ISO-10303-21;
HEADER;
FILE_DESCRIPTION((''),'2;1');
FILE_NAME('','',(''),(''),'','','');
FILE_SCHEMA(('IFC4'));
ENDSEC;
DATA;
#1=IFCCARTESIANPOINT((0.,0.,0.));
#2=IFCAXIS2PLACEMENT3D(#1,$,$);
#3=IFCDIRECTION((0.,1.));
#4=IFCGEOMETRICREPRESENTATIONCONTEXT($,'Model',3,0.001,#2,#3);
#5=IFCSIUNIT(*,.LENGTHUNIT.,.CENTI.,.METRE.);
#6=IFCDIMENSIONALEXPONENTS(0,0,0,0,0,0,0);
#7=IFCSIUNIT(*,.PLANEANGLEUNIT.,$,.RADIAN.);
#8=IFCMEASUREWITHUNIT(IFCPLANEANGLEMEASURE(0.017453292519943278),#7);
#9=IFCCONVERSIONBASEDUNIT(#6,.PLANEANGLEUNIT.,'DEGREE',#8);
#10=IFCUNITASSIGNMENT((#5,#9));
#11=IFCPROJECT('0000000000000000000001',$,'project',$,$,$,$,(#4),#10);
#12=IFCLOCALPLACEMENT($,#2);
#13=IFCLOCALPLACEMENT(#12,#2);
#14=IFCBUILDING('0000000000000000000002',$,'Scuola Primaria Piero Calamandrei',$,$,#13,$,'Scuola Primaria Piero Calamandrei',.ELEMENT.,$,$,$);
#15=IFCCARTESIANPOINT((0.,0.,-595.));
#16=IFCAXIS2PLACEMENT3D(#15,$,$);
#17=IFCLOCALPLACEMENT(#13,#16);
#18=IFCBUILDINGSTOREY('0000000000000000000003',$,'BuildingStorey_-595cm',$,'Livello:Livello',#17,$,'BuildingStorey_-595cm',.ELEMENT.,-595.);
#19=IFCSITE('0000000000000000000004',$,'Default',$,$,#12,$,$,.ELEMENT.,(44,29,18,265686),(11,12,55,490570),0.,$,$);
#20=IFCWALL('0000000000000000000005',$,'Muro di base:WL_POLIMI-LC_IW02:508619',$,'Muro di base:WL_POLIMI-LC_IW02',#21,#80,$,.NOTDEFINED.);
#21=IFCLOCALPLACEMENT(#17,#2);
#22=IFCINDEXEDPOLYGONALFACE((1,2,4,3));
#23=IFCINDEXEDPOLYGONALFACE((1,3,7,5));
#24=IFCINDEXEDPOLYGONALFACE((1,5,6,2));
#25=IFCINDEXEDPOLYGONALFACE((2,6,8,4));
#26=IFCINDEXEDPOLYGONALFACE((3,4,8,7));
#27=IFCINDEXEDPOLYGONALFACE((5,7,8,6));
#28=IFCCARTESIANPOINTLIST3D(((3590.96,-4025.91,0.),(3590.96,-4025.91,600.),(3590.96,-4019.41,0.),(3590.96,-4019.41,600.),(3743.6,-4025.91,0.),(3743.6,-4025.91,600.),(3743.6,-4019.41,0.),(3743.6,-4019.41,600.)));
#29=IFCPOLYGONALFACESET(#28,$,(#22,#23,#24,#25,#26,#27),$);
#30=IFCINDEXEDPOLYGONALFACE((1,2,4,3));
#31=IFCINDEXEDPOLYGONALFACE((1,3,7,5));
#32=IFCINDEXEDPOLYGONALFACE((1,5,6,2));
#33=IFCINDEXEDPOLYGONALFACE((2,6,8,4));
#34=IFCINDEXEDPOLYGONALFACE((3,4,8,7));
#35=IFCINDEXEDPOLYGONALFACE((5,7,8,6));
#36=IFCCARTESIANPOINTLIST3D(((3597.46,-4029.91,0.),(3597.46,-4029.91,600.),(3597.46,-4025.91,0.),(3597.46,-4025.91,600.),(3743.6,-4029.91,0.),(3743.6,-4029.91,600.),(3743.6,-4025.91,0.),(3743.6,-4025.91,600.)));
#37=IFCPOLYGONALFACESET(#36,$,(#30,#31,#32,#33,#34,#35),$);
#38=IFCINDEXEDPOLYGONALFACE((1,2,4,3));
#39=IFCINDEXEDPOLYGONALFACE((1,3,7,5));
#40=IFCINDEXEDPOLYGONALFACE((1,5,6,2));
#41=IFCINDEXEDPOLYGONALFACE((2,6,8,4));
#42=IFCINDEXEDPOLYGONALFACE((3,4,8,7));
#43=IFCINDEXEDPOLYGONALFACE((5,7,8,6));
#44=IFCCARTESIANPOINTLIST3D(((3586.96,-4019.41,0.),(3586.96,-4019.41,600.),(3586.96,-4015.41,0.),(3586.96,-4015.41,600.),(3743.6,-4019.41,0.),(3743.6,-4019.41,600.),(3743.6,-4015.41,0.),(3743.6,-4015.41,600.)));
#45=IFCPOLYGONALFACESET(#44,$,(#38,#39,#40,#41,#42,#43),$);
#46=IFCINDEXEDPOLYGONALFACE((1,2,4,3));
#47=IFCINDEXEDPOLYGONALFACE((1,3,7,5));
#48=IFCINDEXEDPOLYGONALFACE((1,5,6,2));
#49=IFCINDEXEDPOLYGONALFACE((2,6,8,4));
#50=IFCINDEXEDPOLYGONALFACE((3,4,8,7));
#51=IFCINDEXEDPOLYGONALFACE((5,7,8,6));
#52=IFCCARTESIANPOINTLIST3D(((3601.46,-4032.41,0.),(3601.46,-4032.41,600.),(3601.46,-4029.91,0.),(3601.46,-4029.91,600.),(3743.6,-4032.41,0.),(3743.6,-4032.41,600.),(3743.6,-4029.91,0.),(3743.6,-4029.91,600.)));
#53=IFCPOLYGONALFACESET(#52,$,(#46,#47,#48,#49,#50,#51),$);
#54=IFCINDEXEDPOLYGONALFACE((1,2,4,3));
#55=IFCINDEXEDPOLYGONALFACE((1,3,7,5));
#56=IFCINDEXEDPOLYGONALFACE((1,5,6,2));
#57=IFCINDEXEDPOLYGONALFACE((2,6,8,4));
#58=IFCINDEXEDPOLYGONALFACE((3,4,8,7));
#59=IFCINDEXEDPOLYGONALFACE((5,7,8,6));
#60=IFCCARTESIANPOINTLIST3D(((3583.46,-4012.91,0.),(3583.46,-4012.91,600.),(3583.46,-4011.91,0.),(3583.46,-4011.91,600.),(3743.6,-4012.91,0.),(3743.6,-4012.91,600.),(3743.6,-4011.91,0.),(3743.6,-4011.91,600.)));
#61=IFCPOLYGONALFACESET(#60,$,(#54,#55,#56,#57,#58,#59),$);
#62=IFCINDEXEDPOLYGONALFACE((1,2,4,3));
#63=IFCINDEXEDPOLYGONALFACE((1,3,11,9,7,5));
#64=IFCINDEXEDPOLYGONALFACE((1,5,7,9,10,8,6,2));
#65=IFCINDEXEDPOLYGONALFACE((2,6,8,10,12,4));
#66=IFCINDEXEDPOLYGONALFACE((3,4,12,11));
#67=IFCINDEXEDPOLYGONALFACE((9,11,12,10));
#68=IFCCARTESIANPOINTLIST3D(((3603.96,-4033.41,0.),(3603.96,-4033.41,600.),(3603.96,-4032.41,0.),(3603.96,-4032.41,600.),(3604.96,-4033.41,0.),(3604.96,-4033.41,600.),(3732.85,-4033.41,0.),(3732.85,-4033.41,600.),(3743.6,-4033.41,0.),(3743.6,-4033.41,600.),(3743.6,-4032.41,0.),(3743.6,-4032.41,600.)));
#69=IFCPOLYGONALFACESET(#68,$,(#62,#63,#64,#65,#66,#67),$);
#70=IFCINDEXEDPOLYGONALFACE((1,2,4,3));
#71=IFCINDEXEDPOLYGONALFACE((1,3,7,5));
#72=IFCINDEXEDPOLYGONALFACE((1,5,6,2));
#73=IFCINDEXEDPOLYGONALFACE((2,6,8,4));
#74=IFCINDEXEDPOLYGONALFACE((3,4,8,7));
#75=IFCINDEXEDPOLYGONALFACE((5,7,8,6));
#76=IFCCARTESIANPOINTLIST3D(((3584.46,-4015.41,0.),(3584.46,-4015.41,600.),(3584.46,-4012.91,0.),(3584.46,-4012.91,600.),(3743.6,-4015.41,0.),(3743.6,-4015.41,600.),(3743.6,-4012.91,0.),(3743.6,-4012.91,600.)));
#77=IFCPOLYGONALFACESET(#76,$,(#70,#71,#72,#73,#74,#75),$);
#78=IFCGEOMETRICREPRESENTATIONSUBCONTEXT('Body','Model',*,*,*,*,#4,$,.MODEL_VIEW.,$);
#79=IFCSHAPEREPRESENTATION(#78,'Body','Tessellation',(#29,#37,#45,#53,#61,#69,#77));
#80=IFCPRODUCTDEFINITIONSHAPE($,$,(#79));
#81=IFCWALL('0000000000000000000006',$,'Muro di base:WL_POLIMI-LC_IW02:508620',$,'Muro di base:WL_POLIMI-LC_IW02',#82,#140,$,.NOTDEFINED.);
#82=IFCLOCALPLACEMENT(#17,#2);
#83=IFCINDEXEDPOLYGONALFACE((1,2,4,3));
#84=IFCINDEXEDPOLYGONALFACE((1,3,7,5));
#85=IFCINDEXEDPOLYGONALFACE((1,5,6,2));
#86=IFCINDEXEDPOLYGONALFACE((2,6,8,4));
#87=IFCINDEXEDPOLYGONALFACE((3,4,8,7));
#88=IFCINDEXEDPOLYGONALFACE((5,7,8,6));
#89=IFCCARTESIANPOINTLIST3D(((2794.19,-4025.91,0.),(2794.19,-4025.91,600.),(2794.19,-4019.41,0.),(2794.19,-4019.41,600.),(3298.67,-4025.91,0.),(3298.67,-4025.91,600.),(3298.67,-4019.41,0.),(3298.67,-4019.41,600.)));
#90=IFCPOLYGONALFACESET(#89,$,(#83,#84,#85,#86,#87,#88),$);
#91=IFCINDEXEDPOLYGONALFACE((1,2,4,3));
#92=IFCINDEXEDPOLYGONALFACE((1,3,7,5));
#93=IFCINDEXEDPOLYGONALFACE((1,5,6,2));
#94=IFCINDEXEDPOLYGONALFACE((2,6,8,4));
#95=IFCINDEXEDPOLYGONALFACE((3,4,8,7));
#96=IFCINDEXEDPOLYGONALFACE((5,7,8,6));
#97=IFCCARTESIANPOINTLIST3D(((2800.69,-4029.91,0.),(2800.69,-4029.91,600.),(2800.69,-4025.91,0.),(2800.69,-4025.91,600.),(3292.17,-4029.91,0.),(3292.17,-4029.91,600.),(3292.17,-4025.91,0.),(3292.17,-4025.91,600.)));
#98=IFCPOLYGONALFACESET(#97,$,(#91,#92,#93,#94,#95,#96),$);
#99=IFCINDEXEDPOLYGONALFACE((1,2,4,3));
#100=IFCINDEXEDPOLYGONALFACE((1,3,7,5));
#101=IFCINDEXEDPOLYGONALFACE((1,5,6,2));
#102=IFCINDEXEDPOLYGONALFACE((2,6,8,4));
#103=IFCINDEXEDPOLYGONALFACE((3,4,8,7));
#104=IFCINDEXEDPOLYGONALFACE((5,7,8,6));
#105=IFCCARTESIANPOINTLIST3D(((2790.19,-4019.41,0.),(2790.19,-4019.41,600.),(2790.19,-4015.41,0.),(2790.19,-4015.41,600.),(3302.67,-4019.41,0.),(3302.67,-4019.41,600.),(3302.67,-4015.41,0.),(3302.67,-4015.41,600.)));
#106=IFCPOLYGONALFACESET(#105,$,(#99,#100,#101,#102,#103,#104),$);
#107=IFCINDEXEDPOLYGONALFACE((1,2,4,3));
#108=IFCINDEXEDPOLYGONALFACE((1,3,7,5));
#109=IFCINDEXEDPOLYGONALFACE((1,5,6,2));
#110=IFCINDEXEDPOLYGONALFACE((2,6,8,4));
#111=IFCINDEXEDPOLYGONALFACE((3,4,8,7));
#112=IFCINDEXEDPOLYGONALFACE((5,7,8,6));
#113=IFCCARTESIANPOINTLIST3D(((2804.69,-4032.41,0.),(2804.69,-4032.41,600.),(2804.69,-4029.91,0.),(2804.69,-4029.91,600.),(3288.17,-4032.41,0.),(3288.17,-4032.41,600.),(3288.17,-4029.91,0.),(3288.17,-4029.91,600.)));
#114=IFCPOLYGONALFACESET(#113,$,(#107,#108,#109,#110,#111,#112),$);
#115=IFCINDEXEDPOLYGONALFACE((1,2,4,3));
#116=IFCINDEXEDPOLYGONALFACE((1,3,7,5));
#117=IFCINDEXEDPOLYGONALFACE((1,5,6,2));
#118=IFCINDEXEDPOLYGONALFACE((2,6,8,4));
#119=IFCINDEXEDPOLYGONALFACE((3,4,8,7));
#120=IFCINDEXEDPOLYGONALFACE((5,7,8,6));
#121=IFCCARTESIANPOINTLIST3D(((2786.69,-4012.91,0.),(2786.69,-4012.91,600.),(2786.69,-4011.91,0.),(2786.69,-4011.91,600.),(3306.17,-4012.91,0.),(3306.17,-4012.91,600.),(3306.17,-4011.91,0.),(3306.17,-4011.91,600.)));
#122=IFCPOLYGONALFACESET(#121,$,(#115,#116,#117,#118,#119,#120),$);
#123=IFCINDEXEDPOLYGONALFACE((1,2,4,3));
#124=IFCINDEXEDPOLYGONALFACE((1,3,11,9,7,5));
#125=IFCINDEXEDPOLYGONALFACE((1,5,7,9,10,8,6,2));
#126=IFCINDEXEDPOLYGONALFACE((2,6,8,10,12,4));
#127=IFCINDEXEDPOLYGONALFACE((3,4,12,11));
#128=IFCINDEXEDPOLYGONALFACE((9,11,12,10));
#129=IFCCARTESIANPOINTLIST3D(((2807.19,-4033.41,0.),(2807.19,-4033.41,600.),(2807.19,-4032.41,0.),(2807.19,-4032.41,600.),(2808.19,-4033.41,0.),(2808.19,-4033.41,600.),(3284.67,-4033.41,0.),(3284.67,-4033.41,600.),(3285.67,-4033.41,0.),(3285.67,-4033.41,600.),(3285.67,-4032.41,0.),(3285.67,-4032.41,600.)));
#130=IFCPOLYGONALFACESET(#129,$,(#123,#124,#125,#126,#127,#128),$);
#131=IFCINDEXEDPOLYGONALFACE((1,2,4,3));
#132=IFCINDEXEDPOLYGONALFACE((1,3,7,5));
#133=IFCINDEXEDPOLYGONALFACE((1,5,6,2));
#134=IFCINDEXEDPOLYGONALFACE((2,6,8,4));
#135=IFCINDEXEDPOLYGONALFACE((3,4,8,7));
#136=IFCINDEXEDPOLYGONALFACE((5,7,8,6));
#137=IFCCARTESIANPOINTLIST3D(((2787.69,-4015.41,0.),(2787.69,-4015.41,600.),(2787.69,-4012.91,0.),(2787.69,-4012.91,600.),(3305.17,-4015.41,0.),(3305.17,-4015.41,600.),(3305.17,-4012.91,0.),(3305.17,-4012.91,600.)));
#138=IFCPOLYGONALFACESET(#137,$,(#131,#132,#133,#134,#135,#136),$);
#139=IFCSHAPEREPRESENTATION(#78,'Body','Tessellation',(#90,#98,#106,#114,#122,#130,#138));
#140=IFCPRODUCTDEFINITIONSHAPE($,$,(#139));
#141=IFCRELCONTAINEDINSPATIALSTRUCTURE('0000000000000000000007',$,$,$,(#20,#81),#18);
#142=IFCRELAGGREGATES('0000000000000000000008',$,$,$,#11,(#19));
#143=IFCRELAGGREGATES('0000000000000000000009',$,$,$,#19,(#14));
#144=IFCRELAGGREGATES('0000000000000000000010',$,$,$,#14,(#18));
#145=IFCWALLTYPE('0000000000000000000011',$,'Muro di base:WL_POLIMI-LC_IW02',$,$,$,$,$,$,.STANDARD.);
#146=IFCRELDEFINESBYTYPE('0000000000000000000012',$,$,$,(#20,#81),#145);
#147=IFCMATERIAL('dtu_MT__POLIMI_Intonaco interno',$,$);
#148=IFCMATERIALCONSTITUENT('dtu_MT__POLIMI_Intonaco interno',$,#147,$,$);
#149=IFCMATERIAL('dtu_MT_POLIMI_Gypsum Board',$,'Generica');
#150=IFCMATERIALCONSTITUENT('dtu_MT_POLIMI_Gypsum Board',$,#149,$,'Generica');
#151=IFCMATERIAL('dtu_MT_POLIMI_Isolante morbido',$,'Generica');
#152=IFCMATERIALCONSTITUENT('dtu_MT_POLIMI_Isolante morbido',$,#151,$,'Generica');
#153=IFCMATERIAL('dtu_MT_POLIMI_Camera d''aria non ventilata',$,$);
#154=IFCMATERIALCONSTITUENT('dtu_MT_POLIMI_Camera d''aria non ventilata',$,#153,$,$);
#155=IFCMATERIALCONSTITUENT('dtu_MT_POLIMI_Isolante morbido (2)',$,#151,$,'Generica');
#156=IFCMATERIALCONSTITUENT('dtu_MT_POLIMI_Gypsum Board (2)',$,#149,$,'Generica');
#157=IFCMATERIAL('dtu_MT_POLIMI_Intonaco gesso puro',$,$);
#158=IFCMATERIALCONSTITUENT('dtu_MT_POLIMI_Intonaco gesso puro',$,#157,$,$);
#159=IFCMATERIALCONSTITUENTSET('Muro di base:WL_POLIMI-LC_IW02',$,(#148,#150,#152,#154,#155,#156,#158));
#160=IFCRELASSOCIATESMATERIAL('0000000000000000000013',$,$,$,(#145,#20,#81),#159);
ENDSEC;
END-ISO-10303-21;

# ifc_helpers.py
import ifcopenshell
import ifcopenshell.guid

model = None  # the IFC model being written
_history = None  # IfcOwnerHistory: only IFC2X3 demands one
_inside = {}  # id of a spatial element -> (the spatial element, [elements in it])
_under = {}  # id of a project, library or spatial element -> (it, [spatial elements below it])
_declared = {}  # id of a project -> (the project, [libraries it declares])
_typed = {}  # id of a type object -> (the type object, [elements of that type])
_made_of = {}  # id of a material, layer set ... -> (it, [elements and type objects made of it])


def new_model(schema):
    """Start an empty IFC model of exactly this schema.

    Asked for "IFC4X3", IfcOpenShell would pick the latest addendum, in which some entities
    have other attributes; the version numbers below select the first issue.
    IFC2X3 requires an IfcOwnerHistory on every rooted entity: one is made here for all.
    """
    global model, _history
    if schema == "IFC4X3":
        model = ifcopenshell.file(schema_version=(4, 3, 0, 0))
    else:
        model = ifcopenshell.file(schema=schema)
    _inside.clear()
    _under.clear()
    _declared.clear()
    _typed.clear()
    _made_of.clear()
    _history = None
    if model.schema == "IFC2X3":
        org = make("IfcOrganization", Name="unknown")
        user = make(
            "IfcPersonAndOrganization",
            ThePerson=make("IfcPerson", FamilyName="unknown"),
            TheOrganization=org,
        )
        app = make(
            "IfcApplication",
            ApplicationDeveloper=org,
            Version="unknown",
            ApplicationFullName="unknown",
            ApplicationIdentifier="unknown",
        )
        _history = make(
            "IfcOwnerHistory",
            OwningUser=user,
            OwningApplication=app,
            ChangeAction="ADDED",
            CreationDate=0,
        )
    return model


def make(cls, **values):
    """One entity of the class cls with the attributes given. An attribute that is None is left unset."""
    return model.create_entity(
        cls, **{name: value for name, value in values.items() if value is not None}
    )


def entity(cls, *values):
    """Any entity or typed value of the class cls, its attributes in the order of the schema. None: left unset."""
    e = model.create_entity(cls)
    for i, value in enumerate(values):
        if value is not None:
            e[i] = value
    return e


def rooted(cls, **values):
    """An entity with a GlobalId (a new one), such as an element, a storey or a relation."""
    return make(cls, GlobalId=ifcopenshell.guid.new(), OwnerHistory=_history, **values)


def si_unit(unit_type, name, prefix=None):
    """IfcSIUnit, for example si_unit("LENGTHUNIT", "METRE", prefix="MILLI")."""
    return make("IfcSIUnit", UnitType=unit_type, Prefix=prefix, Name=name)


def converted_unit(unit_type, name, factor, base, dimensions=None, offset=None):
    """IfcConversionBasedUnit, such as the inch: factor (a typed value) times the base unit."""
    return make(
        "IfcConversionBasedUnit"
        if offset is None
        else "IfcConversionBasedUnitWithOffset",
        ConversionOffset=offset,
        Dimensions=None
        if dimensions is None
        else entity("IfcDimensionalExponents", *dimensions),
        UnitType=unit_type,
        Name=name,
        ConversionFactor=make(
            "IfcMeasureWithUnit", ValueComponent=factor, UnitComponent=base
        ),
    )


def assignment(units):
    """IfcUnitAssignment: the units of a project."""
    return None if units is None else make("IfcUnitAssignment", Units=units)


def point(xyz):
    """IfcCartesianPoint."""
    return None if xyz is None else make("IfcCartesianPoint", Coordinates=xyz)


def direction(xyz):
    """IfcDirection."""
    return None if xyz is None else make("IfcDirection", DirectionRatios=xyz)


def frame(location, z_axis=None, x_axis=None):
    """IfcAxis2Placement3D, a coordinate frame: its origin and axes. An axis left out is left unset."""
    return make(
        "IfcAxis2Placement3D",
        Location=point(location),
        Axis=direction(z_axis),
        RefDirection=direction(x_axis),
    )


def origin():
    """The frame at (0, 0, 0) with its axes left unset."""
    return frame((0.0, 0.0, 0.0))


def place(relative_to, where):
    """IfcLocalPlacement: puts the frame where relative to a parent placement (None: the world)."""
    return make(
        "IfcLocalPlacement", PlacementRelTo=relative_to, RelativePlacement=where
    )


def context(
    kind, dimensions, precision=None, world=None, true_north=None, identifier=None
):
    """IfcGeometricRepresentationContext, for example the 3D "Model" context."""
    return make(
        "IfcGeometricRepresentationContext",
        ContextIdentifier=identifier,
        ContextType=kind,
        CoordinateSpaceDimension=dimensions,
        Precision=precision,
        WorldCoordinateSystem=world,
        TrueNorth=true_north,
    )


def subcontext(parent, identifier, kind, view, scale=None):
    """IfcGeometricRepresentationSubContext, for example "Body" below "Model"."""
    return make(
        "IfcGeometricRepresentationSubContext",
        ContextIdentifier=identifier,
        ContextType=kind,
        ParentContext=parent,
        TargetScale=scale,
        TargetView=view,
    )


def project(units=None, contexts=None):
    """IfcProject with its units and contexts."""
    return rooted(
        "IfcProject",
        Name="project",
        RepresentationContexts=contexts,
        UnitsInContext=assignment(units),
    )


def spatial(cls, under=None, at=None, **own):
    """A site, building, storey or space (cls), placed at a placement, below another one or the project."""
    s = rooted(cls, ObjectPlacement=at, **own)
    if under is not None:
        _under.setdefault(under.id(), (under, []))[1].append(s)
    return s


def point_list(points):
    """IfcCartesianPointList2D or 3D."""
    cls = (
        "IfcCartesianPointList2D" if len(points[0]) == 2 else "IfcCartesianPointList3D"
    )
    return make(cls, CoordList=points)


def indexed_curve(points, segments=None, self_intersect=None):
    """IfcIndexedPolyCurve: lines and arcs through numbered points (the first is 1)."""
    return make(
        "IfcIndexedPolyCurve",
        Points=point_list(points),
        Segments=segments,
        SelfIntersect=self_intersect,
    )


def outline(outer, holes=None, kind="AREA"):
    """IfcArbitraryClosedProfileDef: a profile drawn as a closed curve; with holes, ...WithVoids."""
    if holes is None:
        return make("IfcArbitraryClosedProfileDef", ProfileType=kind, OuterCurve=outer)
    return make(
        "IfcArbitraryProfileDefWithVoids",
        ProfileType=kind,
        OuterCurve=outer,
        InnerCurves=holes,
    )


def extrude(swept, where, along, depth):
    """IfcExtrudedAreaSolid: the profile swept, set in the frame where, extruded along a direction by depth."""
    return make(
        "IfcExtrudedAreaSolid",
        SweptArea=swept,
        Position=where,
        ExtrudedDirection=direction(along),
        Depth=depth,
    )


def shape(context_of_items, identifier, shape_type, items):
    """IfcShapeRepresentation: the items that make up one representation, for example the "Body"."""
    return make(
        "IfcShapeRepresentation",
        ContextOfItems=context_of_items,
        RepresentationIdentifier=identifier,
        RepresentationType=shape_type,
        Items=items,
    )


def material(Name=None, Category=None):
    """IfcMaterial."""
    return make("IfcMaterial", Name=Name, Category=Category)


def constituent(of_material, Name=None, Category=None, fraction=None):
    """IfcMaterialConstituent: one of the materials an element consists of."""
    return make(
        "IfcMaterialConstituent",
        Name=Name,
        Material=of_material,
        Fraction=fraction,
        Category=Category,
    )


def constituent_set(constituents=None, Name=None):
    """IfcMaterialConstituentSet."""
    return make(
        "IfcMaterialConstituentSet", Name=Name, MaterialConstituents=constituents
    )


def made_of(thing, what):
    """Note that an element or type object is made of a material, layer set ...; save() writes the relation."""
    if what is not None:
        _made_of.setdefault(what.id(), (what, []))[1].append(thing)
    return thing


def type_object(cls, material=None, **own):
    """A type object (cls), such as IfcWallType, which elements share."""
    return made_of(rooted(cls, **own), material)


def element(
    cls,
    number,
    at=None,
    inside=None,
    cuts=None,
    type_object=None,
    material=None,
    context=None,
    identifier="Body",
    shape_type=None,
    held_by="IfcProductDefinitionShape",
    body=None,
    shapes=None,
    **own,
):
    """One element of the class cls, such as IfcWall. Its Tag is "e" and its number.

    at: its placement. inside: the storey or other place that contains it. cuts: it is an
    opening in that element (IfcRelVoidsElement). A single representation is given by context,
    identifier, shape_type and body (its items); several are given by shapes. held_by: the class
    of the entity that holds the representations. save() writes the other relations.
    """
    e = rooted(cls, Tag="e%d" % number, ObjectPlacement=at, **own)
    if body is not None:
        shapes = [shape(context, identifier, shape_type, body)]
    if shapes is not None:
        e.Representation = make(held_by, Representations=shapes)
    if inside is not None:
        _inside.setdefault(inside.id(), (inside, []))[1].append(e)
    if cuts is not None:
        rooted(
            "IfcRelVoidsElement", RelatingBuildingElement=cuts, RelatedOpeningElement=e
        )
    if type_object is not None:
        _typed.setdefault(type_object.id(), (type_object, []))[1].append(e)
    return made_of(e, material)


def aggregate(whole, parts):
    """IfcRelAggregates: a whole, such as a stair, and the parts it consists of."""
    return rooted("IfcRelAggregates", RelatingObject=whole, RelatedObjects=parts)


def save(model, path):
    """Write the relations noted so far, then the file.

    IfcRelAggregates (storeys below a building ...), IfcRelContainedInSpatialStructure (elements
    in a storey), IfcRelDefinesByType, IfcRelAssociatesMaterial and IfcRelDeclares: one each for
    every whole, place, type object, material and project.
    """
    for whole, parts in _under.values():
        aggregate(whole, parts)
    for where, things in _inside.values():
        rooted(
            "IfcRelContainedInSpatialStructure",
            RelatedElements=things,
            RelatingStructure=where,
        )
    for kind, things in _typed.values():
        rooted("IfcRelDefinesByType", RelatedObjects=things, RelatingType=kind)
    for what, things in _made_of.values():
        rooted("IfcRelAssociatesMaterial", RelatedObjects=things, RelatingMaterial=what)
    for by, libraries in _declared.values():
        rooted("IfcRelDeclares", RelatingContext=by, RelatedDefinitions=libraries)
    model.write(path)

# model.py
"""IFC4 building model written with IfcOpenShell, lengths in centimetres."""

from ifc_helpers import new_model, entity, si_unit, converted_unit, direction, frame, origin, place, context, subcontext, project, spatial, indexed_curve, outline, extrude, material, constituent, constituent_set, type_object, element, save


model = new_model("IFC4")

# Units and contexts
model_context = context("Model", 3, precision=0.001, world=origin(), true_north=direction((0.0, 1.0)))
body_context = subcontext(model_context, "Body", "Model", "MODEL_VIEW")
ifc_project = project(units=[si_unit("LENGTHUNIT", "METRE", prefix="CENTI"), converted_unit("PLANEANGLEUNIT", "DEGREE", entity("IfcPlaneAngleMeasure", 0.017453292519943278), si_unit("PLANEANGLEUNIT", "RADIAN"), dimensions=[0, 0, 0, 0, 0, 0, 0])], contexts=[model_context])

# Site, building, storey
site_placement = place(None, origin())
site = spatial("IfcSite", under=ifc_project, at=site_placement, Name="Default", CompositionType="ELEMENT", RefLatitude=(44, 29, 18, 265686), RefLongitude=(11, 12, 55, 490570), RefElevation=0.0)
building_placement = place(site_placement, origin())
building = spatial("IfcBuilding", under=site, at=building_placement, Name="Scuola Primaria Piero Calamandrei", LongName="Scuola Primaria Piero Calamandrei", CompositionType="ELEMENT")
storey_placement = place(building_placement, frame((0.0, 0.0, -595.0)))
storey = spatial("IfcBuildingStorey", under=building, at=storey_placement, Name="BuildingStorey_-595cm", ObjectType="Livello:Livello", LongName="BuildingStorey_-595cm", CompositionType="ELEMENT", Elevation=-595.0)

# Walls
ifc_material_1 = material(Name="dtu_MT__POLIMI_Intonaco interno")
ifc_constituent_1 = constituent(ifc_material_1, Name="dtu_MT__POLIMI_Intonaco interno")
ifc_material_2 = material(Name="dtu_MT_POLIMI_Gypsum Board", Category="Generica")
ifc_constituent_2 = constituent(ifc_material_2, Name="dtu_MT_POLIMI_Gypsum Board", Category="Generica")
ifc_material_3 = material(Name="dtu_MT_POLIMI_Isolante morbido", Category="Generica")
ifc_constituent_3 = constituent(ifc_material_3, Name="dtu_MT_POLIMI_Isolante morbido", Category="Generica")
ifc_material_4 = material(Name="dtu_MT_POLIMI_Camera d'aria non ventilata")
ifc_constituent_4 = constituent(ifc_material_4, Name="dtu_MT_POLIMI_Camera d'aria non ventilata")
ifc_constituent_5 = constituent(ifc_material_3, Name="dtu_MT_POLIMI_Isolante morbido (2)", Category="Generica")
ifc_constituent_6 = constituent(ifc_material_2, Name="dtu_MT_POLIMI_Gypsum Board (2)", Category="Generica")
ifc_material_5 = material(Name="dtu_MT_POLIMI_Intonaco gesso puro")
ifc_constituent_7 = constituent(ifc_material_5, Name="dtu_MT_POLIMI_Intonaco gesso puro")
ifc_constituent_set_1 = constituent_set(constituents=[ifc_constituent_1, ifc_constituent_2, ifc_constituent_3, ifc_constituent_4, ifc_constituent_5, ifc_constituent_6, ifc_constituent_7], Name="Muro di base:WL_POLIMI-LC_IW02")
wall_type_1 = type_object("IfcWallType", Name="Muro di base:WL_POLIMI-LC_IW02", PredefinedType="STANDARD", material=ifc_constituent_set_1)
wall_1_placement = place(storey_placement, frame((3743.6, -4022.66, 0.0), z_axis=(0.0, 0.0, 1.0), x_axis=(-1.0, 0.0, 0.0)))
element("IfcWall", 1, at=wall_1_placement, inside=storey, type_object=wall_type_1, material=ifc_constituent_set_1, Name="Muro di base:WL_POLIMI-LC_IW02:508619", ObjectType="Muro di base:WL_POLIMI-LC_IW02", PredefinedType="NOTDEFINED", context=body_context, shape_type="SweptSolid", body=[
    extrude(outline(indexed_curve([(-76.32, -3.25), (76.32, -3.25), (76.32, 3.25), (-76.32, 3.25), (-76.32, -3.25)], self_intersect=False)), frame((76.32, 0.0, 0.0)), (0.0, 0.0, 1.0), 600.0),
    extrude(outline(indexed_curve([(-73.07, -2.0), (73.07, -2.0), (73.07, 2.0), (-73.07, 2.0), (-73.07, -2.0)], self_intersect=False)), frame((73.07, 5.25, 0.0)), (0.0, 0.0, 1.0), 600.0),
    extrude(outline(indexed_curve([(-78.32, -2.0), (78.32, -2.0), (78.32, 2.0), (-78.32, 2.0), (-78.32, -2.0)], self_intersect=False)), frame((78.32, -5.25, 0.0)), (0.0, 0.0, 1.0), 600.0),
    extrude(outline(indexed_curve([(-71.07, -1.25), (71.07, -1.25), (71.07, 1.25), (-71.07, 1.25), (-71.07, -1.25)], self_intersect=False)), frame((71.07, 8.5, 0.0)), (0.0, 0.0, 1.0), 600.0),
    extrude(outline(indexed_curve([(-0.5, -80.07), (0.5, -80.07), (0.5, 80.07), (-0.5, 80.07), (-0.5, -80.07)], self_intersect=False)), frame((80.07, -10.25, 0.0), z_axis=(0.0, 0.0, 1.0), x_axis=(0.0, 1.0, 0.0)), (0.0, 0.0, 1.0), 600.0),
    extrude(outline(indexed_curve([(-67.2, -0.33), (60.7, -0.33), (71.45, -0.33), (71.45, 0.67), (-68.2, 0.67), (-68.2, -0.33), (-67.2, -0.33)], self_intersect=False)), frame((71.45, 10.42, 0.0), z_axis=(0.0, 0.0, 1.0), x_axis=(-1.0, 0.0, 0.0)), (0.0, 0.0, 1.0), 600.0),
    extrude(outline(indexed_curve([(-79.57, -1.25), (79.57, -1.25), (79.57, 1.25), (-79.57, 1.25), (-79.57, -1.25)], self_intersect=False)), frame((79.57, -8.5, 0.0)), (0.0, 0.0, 1.0), 600.0),
])
wall_2_placement = place(storey_placement, frame((3306.17, -4022.66, 0.0), z_axis=(0.0, 0.0, 1.0), x_axis=(-1.0, 0.0, 0.0)))
element("IfcWall", 2, at=wall_2_placement, inside=storey, type_object=wall_type_1, material=ifc_constituent_set_1, Name="Muro di base:WL_POLIMI-LC_IW02:508620", ObjectType="Muro di base:WL_POLIMI-LC_IW02", PredefinedType="NOTDEFINED", context=body_context, shape_type="SweptSolid", body=[
    extrude(outline(indexed_curve([(-252.24, -3.25), (252.24, -3.25), (252.24, 3.25), (-252.24, 3.25), (-252.24, -3.25)], self_intersect=False)), frame((259.74, 0.0, 0.0)), (0.0, 0.0, 1.0), 600.0),
    extrude(outline(indexed_curve([(-245.74, -2.0), (245.74, -2.0), (245.74, 2.0), (-245.74, 2.0), (-245.74, -2.0)], self_intersect=False)), frame((259.74, 5.25, 0.0)), (0.0, 0.0, 1.0), 600.0),
    extrude(outline(indexed_curve([(-256.24, -2.0), (256.24, -2.0), (256.24, 2.0), (-256.24, 2.0), (-256.24, -2.0)], self_intersect=False)), frame((259.74, -5.25, 0.0)), (0.0, 0.0, 1.0), 600.0),
    extrude(outline(indexed_curve([(-241.74, -1.25), (241.74, -1.25), (241.74, 1.25), (-241.74, 1.25), (-241.74, -1.25)], self_intersect=False)), frame((259.74, 8.5, 0.0)), (0.0, 0.0, 1.0), 600.0),
    extrude(outline(indexed_curve([(-0.5, -259.74), (0.5, -259.74), (0.5, 259.74), (-0.5, 259.74), (-0.5, -259.74)], self_intersect=False)), frame((259.74, -10.25, 0.0), z_axis=(0.0, 0.0, 1.0), x_axis=(0.0, 1.0, 0.0)), (0.0, 0.0, 1.0), 600.0),
    extrude(outline(indexed_curve([(-238.24, -0.33), (238.24, -0.33), (239.24, -0.33), (239.24, 0.67), (-239.24, 0.67), (-239.24, -0.33), (-238.24, -0.33)], self_intersect=False)), frame((259.74, 10.42, 0.0), z_axis=(0.0, 0.0, 1.0), x_axis=(-1.0, 0.0, 0.0)), (0.0, 0.0, 1.0), 600.0),
    extrude(outline(indexed_curve([(-258.74, -1.25), (258.74, -1.25), (258.74, 1.25), (-258.74, 1.25), (-258.74, -1.25)], self_intersect=False)), frame((259.74, -8.5, 0.0)), (0.0, 0.0, 1.0), 600.0),
])

save(model, "model.ifc")
